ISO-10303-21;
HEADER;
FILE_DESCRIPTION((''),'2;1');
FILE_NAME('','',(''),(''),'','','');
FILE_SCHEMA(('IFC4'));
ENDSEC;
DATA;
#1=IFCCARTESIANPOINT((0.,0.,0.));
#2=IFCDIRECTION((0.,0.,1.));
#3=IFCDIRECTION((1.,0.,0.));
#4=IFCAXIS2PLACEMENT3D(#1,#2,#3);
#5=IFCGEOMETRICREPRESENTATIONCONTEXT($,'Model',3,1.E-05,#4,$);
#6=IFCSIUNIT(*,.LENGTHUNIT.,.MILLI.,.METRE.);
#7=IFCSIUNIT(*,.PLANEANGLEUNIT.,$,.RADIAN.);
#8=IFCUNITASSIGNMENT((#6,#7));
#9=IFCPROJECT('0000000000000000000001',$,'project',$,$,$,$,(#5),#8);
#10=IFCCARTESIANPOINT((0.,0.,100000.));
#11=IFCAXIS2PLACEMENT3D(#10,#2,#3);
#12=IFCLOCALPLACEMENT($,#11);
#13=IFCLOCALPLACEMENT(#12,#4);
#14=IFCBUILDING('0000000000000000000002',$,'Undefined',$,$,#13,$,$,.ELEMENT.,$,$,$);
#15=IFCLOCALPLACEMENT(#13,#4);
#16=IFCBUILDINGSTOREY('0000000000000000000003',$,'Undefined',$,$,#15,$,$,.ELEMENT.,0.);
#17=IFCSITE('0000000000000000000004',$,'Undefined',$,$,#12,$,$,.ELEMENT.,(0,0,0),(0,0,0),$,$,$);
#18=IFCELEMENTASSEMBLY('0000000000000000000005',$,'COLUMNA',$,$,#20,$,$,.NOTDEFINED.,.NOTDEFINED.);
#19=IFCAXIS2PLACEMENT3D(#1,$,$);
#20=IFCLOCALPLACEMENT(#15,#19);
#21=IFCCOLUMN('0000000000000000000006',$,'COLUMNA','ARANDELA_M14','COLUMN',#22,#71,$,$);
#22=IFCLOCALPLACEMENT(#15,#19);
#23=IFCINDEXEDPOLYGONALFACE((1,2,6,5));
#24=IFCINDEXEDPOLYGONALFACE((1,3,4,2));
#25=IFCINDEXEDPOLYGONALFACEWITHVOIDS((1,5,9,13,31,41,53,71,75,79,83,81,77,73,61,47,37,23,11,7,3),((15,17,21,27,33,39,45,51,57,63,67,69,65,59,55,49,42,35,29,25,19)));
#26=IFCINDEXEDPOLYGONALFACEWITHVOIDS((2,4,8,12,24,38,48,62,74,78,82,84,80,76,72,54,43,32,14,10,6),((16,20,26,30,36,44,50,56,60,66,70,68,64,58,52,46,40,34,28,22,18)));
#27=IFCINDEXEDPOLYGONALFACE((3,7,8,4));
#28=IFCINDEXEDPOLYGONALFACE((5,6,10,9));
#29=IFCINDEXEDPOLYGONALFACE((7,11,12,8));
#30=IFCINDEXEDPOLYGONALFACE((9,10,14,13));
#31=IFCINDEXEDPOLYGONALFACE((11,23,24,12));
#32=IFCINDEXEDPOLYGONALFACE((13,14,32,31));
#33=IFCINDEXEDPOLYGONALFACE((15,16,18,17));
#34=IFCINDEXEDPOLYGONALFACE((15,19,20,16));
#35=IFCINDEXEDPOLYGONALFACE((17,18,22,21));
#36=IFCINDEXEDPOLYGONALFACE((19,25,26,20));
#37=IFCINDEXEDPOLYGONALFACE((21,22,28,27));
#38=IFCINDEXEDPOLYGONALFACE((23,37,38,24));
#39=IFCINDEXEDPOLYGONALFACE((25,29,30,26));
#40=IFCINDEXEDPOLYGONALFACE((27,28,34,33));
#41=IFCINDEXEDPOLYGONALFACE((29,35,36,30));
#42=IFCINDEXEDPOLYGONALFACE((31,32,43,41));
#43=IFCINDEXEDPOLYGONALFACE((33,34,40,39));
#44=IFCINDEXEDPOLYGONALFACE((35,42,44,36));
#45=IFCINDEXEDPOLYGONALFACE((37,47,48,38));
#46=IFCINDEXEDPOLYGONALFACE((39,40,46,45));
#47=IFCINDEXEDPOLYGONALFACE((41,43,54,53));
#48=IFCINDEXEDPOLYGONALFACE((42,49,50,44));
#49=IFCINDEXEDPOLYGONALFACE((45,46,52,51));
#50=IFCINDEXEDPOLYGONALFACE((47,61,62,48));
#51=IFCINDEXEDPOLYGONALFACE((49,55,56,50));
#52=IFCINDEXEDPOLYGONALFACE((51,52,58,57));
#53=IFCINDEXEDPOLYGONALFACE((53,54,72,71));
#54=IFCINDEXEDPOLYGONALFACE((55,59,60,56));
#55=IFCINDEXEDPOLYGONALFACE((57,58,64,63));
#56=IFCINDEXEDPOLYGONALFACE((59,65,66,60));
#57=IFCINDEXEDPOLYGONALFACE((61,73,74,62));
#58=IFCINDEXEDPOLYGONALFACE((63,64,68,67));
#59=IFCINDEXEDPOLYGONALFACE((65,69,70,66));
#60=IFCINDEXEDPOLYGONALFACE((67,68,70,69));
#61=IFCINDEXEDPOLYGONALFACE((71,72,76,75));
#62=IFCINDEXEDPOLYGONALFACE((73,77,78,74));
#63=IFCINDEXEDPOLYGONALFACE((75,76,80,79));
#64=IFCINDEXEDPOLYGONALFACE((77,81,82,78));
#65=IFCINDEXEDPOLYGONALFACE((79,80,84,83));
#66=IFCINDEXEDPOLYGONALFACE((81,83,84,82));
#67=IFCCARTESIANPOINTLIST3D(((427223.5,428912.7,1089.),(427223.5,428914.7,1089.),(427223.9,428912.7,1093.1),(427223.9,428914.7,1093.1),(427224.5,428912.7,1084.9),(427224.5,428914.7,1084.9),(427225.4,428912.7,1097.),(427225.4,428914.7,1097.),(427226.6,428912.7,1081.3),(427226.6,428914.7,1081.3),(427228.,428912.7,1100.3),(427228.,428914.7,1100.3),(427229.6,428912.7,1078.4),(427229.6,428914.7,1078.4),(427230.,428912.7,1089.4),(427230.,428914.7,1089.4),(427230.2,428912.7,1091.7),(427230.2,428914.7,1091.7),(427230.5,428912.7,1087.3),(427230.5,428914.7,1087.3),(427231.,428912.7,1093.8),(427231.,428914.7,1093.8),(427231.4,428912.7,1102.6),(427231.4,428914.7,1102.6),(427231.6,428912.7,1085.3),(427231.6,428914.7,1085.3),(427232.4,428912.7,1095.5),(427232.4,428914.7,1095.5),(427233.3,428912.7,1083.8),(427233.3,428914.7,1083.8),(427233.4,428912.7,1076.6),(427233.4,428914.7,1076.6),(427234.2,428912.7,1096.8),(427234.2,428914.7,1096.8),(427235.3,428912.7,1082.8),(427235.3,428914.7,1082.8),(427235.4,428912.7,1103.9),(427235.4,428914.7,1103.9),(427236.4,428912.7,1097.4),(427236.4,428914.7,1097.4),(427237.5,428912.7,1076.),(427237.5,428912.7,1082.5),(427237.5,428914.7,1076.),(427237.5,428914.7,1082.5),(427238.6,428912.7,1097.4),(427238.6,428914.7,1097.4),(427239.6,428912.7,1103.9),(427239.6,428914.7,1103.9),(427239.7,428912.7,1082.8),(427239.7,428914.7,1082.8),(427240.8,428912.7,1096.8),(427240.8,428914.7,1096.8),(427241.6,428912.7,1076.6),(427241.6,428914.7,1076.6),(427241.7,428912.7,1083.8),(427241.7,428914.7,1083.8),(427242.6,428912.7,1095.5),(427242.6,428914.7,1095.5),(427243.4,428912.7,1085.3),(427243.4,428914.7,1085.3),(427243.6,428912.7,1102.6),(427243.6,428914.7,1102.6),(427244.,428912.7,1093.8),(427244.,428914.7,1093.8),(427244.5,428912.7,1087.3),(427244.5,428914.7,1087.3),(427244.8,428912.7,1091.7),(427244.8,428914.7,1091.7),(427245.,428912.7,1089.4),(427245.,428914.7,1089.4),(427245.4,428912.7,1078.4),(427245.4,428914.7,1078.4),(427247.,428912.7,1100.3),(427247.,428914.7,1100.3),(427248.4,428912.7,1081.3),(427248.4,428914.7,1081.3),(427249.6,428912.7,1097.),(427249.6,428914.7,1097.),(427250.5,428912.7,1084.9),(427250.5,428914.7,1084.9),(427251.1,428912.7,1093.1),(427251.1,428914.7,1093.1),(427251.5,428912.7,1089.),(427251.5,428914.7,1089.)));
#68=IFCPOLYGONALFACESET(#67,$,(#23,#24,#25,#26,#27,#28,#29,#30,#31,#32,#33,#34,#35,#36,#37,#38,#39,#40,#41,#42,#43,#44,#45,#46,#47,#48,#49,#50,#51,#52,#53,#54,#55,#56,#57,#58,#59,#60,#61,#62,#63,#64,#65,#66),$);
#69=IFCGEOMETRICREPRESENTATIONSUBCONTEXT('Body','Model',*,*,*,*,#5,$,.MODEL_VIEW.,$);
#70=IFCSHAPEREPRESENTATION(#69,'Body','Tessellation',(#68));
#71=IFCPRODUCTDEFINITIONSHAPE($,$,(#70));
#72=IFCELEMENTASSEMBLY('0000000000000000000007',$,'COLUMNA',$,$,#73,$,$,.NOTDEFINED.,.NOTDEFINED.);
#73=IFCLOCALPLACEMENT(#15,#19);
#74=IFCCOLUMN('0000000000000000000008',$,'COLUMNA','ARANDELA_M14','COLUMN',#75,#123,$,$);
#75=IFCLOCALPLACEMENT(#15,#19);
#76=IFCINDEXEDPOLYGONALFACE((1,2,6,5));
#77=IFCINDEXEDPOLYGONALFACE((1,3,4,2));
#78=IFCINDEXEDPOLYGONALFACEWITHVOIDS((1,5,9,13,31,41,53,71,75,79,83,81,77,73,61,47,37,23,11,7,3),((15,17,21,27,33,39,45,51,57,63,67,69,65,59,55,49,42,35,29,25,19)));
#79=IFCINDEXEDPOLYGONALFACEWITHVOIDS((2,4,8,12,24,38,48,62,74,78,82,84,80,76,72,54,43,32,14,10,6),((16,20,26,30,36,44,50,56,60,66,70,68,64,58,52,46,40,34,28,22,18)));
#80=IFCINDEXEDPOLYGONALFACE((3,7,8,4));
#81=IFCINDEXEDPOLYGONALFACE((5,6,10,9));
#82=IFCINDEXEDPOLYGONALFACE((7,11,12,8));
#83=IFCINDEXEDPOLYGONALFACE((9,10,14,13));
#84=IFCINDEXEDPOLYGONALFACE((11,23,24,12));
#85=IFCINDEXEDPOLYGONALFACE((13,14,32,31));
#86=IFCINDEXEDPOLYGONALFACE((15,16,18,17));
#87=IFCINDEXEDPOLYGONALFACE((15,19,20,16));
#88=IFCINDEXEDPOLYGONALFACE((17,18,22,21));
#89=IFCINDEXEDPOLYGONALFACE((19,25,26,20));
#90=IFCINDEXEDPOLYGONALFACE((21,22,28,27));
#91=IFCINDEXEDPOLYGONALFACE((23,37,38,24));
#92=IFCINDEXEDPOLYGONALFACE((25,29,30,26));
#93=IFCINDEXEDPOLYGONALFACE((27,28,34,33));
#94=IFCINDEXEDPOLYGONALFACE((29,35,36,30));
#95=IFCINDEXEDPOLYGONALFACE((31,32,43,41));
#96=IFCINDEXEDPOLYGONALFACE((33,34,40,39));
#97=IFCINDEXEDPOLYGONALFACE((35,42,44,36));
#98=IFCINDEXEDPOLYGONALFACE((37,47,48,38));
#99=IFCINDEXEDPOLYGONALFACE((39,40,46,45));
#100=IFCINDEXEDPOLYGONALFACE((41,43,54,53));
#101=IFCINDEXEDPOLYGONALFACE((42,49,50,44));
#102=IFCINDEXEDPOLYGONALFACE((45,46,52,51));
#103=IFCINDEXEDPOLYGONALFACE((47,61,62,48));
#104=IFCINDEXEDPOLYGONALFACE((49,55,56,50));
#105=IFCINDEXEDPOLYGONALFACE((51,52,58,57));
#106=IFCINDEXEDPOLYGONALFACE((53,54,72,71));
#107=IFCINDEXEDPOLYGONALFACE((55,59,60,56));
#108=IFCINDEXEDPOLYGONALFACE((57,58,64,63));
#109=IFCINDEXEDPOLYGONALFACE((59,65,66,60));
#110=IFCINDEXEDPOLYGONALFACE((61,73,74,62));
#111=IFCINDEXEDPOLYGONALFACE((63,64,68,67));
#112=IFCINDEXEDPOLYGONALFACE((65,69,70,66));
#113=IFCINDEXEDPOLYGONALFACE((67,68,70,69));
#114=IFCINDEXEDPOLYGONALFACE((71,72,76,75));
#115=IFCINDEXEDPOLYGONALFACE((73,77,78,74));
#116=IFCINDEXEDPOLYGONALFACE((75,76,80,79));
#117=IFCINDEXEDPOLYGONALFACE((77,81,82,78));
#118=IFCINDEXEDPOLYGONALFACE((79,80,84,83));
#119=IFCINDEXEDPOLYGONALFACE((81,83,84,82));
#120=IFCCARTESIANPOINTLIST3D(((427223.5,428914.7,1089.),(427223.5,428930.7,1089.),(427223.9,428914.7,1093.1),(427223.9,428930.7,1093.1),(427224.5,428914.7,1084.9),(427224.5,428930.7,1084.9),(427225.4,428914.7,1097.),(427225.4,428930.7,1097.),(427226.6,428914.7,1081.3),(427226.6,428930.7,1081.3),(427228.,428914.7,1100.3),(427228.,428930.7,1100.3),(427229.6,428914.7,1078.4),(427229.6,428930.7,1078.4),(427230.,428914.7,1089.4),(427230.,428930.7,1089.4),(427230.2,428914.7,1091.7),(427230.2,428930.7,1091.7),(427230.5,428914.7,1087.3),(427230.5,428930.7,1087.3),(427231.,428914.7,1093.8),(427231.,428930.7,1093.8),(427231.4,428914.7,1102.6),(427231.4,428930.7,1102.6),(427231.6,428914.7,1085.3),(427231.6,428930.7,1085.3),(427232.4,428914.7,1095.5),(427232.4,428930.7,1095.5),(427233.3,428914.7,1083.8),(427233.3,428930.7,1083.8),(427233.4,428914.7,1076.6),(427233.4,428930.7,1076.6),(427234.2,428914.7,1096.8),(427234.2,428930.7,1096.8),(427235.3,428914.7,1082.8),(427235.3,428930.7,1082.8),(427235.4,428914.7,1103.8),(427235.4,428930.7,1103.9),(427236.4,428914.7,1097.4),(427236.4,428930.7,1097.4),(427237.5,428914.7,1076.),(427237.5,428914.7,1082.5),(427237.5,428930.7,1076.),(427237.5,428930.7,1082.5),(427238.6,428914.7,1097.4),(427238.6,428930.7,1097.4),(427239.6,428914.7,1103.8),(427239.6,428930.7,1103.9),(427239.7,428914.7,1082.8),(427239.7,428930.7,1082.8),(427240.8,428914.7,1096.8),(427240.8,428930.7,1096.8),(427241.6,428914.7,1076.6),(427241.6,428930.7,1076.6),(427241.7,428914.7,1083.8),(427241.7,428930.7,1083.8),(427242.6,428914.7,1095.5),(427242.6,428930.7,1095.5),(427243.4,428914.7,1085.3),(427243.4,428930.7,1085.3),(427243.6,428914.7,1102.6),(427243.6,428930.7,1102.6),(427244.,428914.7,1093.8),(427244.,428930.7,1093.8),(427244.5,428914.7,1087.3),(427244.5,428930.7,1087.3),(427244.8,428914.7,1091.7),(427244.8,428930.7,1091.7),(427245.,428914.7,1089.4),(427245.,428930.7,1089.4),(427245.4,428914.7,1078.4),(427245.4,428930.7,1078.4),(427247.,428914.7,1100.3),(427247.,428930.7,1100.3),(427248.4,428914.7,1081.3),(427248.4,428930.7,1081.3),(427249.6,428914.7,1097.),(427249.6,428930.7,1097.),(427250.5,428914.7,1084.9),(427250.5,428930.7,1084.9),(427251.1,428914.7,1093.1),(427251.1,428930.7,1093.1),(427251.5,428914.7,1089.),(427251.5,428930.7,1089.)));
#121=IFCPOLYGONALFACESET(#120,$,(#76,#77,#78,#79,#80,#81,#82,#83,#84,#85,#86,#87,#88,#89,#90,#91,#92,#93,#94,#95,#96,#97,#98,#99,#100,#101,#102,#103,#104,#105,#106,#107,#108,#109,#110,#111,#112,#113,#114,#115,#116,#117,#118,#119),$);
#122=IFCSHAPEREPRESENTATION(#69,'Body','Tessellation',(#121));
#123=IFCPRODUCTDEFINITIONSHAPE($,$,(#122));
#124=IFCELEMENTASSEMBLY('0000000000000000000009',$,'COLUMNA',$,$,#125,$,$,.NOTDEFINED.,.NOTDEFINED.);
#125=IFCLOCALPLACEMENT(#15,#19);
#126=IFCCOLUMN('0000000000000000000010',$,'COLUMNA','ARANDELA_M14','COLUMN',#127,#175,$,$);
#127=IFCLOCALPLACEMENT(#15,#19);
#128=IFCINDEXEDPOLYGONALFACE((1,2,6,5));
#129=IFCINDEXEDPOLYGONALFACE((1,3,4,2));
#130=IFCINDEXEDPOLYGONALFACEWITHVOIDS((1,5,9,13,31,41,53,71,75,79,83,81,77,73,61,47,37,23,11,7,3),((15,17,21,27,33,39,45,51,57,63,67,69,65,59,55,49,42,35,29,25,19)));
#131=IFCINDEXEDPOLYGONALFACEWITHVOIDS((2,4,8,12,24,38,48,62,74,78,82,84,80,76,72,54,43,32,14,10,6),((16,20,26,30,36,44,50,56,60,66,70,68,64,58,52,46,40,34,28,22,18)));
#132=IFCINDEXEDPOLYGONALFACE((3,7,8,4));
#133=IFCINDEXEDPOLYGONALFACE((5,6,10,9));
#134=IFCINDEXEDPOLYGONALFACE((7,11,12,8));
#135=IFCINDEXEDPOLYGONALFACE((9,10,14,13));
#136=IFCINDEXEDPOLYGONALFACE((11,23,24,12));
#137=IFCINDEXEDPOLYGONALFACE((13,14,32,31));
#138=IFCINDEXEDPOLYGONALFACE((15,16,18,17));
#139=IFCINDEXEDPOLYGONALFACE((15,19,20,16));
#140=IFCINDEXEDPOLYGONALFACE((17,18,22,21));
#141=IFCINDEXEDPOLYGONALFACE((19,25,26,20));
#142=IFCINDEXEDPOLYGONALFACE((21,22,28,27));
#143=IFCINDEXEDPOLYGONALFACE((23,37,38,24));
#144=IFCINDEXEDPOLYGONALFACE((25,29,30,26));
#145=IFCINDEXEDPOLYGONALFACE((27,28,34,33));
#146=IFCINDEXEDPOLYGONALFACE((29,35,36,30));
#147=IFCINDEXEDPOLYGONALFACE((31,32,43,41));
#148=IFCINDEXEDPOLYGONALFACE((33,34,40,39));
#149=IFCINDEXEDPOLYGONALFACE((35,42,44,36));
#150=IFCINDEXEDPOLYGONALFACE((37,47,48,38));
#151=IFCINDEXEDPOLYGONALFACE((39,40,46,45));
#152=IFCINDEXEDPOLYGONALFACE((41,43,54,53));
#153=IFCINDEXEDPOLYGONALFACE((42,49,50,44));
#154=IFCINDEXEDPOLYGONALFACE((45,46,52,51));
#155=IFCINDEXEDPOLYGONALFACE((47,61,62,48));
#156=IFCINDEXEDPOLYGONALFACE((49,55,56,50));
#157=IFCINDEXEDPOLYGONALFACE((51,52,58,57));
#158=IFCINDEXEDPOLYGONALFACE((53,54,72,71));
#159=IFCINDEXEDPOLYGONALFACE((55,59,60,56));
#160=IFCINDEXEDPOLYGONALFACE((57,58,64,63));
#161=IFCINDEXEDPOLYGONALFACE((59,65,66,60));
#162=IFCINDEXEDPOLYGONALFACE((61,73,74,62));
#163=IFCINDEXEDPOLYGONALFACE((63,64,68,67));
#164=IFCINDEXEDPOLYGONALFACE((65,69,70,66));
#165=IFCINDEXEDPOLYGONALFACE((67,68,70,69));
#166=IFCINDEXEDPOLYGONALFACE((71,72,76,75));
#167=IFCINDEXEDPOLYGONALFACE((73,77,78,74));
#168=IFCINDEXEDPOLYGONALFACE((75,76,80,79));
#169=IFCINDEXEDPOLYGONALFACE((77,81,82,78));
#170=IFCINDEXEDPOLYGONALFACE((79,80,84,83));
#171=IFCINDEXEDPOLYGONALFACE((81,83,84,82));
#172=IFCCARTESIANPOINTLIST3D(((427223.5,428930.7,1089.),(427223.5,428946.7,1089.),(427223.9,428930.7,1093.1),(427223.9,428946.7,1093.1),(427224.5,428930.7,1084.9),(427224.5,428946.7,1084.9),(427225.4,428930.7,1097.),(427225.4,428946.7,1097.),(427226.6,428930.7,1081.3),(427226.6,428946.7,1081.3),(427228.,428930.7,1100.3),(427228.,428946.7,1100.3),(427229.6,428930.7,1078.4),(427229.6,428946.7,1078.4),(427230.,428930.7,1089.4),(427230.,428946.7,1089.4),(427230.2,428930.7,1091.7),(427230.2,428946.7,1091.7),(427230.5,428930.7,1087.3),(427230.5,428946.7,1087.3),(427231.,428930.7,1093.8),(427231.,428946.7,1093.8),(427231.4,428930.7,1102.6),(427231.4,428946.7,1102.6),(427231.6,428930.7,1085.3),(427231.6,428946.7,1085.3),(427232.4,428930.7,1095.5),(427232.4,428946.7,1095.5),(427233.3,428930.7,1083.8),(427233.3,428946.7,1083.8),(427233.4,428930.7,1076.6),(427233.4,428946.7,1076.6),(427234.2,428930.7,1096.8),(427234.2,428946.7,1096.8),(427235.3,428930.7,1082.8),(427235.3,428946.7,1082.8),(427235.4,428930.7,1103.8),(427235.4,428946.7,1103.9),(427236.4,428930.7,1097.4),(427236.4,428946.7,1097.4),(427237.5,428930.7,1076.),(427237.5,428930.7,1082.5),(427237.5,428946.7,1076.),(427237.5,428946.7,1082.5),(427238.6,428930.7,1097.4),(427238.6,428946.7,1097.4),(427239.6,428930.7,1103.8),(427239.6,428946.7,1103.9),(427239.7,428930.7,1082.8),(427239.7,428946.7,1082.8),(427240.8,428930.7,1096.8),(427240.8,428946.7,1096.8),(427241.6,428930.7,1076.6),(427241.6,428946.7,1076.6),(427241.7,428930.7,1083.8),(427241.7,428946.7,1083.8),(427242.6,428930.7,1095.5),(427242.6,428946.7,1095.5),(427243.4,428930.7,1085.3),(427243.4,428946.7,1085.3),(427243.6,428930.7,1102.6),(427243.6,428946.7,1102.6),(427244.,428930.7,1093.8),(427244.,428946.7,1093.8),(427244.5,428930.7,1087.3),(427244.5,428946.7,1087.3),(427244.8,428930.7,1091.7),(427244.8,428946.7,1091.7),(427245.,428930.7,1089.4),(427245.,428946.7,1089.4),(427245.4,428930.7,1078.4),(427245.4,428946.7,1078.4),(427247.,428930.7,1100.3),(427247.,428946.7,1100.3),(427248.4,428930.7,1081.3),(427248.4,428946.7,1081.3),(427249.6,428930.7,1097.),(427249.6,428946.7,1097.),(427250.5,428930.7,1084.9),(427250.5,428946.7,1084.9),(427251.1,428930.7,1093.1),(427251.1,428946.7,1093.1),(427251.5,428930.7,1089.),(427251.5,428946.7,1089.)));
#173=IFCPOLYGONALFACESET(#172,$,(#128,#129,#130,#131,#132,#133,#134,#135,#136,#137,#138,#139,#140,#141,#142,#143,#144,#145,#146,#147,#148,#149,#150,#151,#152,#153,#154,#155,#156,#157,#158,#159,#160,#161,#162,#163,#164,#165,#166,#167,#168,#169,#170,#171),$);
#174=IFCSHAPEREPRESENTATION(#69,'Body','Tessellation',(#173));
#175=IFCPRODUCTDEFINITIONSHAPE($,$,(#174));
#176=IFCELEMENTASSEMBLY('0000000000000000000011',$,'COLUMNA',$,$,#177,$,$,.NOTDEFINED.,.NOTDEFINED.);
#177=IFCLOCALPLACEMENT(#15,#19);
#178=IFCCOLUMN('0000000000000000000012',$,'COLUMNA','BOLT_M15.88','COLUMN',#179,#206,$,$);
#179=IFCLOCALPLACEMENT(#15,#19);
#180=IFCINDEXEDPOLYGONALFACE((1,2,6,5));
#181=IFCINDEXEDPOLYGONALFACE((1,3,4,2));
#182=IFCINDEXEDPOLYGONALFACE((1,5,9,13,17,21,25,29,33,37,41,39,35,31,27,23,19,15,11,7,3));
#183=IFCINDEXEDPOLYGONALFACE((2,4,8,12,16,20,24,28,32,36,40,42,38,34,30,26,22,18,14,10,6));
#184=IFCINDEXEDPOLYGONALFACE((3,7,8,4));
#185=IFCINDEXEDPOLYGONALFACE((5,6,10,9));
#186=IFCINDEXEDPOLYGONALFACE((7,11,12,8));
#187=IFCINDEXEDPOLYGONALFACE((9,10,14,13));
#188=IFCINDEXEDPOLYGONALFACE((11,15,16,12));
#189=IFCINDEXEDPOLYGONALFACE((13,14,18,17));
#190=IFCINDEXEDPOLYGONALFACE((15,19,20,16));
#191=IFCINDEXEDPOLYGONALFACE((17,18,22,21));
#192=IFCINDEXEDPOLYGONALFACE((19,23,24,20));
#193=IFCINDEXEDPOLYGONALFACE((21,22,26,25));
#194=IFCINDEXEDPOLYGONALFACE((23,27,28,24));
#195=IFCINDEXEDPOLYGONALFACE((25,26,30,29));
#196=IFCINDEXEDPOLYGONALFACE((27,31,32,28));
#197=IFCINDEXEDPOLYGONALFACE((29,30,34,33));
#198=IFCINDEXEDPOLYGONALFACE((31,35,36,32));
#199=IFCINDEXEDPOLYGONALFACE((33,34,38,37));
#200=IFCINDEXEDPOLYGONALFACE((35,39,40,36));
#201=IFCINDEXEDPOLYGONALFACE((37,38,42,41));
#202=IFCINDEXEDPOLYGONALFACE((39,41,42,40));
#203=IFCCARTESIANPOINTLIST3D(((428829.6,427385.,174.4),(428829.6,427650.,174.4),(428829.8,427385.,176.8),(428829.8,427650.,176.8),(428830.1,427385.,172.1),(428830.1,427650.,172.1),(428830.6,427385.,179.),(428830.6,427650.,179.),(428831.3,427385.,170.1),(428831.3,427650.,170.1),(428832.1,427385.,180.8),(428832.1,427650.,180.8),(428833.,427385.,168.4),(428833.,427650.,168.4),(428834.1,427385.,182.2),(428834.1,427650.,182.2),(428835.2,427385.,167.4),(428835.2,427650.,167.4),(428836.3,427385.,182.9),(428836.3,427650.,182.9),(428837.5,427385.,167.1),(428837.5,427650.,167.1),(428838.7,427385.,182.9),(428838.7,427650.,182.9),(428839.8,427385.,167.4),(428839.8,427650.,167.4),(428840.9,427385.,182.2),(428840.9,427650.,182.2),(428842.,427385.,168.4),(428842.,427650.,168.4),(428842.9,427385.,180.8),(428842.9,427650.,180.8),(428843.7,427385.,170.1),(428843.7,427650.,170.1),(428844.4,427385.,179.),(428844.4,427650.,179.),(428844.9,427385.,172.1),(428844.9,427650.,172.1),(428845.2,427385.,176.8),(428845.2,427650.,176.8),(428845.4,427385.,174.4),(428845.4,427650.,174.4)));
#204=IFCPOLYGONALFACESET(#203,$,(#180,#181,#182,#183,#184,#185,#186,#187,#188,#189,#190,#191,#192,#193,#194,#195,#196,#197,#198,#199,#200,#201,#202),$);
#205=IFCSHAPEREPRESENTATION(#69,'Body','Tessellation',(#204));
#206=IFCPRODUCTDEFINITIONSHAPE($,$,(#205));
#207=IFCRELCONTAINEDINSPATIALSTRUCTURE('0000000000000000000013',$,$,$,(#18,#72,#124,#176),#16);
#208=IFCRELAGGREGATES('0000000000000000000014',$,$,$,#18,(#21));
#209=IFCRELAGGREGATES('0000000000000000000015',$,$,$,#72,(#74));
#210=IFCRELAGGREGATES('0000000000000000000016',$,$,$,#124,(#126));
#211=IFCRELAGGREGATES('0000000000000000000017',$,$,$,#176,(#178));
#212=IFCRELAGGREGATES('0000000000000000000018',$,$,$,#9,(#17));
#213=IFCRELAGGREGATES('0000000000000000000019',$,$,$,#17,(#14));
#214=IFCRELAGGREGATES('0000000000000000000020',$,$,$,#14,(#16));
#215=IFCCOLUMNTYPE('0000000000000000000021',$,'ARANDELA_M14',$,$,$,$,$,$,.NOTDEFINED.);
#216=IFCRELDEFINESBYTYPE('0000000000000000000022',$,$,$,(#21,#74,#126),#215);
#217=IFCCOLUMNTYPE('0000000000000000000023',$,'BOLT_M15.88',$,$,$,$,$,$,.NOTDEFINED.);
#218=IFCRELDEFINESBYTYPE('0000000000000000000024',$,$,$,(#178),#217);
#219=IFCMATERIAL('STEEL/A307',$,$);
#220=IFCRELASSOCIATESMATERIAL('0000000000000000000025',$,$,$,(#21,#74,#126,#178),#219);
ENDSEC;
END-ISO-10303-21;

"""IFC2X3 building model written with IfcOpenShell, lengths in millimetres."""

from ifc_helpers import new_model, si_unit, frame, origin_with_axes, origin_2d_with_axis, place, context, subcontext, project, spatial, circle, hollow_circle, extrude, material, type_object, element, aggregate, save


model = new_model("IFC2X3")

# Units and contexts
model_context = context("Model", 3, precision=1e-05, world=origin_with_axes())
body_context = subcontext(model_context, "Body", "Model", "MODEL_VIEW")
ifc_project = project(units=[si_unit("LENGTHUNIT", "METRE", prefix="MILLI"), si_unit("PLANEANGLEUNIT", "RADIAN")], contexts=[model_context])

# Site, building, storey
site_placement = place(None, frame((0.0, 0.0, 100000.0), z_axis=(0.0, 0.0, 1.0), x_axis=(1.0, 0.0, 0.0)))
site = spatial("IfcSite", under=ifc_project, at=site_placement, Name="Undefined", CompositionType="ELEMENT", RefLatitude=(0, 0, 0), RefLongitude=(0, 0, 0))
building_placement = place(site_placement, origin_with_axes())
building = spatial("IfcBuilding", under=site, at=building_placement, Name="Undefined", CompositionType="ELEMENT")
storey_placement = place(building_placement, origin_with_axes())
storey = spatial("IfcBuildingStorey", under=building, at=storey_placement, Name="Undefined", CompositionType="ELEMENT", Elevation=0.0)

# Element assemblies, columns
ifc_material_1 = material(Name="STEEL/A307")
column_type_1 = type_object("IfcColumnType", Name="ARANDELA_M14", PredefinedType="NOTDEFINED")
assembly_1_placement = place(storey_placement, origin_with_axes())
assembly_1 = element("IfcElementAssembly", 1, at=assembly_1_placement, inside=storey, Name="COLUMNA", AssemblyPlace="NOTDEFINED", PredefinedType="NOTDEFINED")
column_1_placement = place(assembly_1_placement, frame((427237.5, 428912.7, 1090.0), z_axis=(0.0, 1.0, 0.000285), x_axis=(1.0, 0.0, 0.0)))
column_1 = element("IfcColumn", 2, at=column_1_placement, type_object=column_type_1, material=ifc_material_1, Name="COLUMNA", Description="ARANDELA_M14", ObjectType="COLUMN", context=body_context, shape_type="SweptSolid", body=[
    extrude(hollow_circle(Radius=14.0, WallThickness=6.5, at=origin_2d_with_axis()), frame((0.0, 0.0, 2.0), z_axis=(0.0, 0.0, -1.0), x_axis=(0.0, 1.0, 0.0)), (0.0, 0.0, 1.0), 2.0),
])
aggregate(assembly_1, [column_1])
assembly_2_placement = place(storey_placement, origin_with_axes())
assembly_2 = element("IfcElementAssembly", 3, at=assembly_2_placement, inside=storey, Name="COLUMNA", AssemblyPlace="NOTDEFINED", PredefinedType="NOTDEFINED")
column_2_placement = place(assembly_2_placement, frame((427237.5, 428914.7, 1090.0), z_axis=(0.0, 1.0, 0.000285), x_axis=(1.0, 0.0, 0.0)))
column_2 = element("IfcColumn", 4, at=column_2_placement, type_object=column_type_1, material=ifc_material_1, Name="COLUMNA", Description="ARANDELA_M14", ObjectType="COLUMN", context=body_context, shape_type="SweptSolid", body=[
    extrude(hollow_circle(Radius=14.0, WallThickness=6.5, at=origin_2d_with_axis()), frame((0.0, 0.0, 16.0), z_axis=(0.0, 0.0, -1.0), x_axis=(0.0, 1.0, 0.0)), (0.0, 0.0, 1.0), 16.0),
])
aggregate(assembly_2, [column_2])
assembly_3_placement = place(storey_placement, origin_with_axes())
assembly_3 = element("IfcElementAssembly", 5, at=assembly_3_placement, inside=storey, Name="COLUMNA", AssemblyPlace="NOTDEFINED", PredefinedType="NOTDEFINED")
column_3_placement = place(assembly_3_placement, frame((427237.5, 428930.7, 1090.0), z_axis=(0.0, 1.0, 0.000285), x_axis=(1.0, 0.0, 0.0)))
column_3 = element("IfcColumn", 6, at=column_3_placement, type_object=column_type_1, material=ifc_material_1, Name="COLUMNA", Description="ARANDELA_M14", ObjectType="COLUMN", context=body_context, shape_type="SweptSolid", body=[
    extrude(hollow_circle(Radius=14.0, WallThickness=6.5, at=origin_2d_with_axis()), frame((0.0, 0.0, 16.0), z_axis=(0.0, 0.0, -1.0), x_axis=(0.0, 1.0, 0.0)), (0.0, 0.0, 1.0), 16.0),
])
aggregate(assembly_3, [column_3])
assembly_4_placement = place(storey_placement, origin_with_axes())
assembly_4 = element("IfcElementAssembly", 7, at=assembly_4_placement, inside=storey, Name="COLUMNA", AssemblyPlace="NOTDEFINED", PredefinedType="NOTDEFINED")
column_type_2 = type_object("IfcColumnType", Name="BOLT_M15.88", PredefinedType="NOTDEFINED")
column_4_placement = place(assembly_4_placement, frame((428837.5, 427650.0, 175.0), z_axis=(0.0, -1.0, -0.000003), x_axis=(-1.0, 0.0, 0.0)))
column_4 = element("IfcColumn", 8, at=column_4_placement, type_object=column_type_2, material=ifc_material_1, Name="COLUMNA", Description="BOLT_M15.88", ObjectType="COLUMN", context=body_context, shape_type="SweptSolid", body=[
    extrude(circle(Radius=7.9, at=origin_2d_with_axis()), frame((0.0, 0.0, 265.0), z_axis=(0.0, 0.0, -1.0), x_axis=(0.0, 1.0, 0.0)), (0.0, 0.0, 1.0), 265.0),
])
aggregate(assembly_4, [column_4])

save(model, "model.ifc")
